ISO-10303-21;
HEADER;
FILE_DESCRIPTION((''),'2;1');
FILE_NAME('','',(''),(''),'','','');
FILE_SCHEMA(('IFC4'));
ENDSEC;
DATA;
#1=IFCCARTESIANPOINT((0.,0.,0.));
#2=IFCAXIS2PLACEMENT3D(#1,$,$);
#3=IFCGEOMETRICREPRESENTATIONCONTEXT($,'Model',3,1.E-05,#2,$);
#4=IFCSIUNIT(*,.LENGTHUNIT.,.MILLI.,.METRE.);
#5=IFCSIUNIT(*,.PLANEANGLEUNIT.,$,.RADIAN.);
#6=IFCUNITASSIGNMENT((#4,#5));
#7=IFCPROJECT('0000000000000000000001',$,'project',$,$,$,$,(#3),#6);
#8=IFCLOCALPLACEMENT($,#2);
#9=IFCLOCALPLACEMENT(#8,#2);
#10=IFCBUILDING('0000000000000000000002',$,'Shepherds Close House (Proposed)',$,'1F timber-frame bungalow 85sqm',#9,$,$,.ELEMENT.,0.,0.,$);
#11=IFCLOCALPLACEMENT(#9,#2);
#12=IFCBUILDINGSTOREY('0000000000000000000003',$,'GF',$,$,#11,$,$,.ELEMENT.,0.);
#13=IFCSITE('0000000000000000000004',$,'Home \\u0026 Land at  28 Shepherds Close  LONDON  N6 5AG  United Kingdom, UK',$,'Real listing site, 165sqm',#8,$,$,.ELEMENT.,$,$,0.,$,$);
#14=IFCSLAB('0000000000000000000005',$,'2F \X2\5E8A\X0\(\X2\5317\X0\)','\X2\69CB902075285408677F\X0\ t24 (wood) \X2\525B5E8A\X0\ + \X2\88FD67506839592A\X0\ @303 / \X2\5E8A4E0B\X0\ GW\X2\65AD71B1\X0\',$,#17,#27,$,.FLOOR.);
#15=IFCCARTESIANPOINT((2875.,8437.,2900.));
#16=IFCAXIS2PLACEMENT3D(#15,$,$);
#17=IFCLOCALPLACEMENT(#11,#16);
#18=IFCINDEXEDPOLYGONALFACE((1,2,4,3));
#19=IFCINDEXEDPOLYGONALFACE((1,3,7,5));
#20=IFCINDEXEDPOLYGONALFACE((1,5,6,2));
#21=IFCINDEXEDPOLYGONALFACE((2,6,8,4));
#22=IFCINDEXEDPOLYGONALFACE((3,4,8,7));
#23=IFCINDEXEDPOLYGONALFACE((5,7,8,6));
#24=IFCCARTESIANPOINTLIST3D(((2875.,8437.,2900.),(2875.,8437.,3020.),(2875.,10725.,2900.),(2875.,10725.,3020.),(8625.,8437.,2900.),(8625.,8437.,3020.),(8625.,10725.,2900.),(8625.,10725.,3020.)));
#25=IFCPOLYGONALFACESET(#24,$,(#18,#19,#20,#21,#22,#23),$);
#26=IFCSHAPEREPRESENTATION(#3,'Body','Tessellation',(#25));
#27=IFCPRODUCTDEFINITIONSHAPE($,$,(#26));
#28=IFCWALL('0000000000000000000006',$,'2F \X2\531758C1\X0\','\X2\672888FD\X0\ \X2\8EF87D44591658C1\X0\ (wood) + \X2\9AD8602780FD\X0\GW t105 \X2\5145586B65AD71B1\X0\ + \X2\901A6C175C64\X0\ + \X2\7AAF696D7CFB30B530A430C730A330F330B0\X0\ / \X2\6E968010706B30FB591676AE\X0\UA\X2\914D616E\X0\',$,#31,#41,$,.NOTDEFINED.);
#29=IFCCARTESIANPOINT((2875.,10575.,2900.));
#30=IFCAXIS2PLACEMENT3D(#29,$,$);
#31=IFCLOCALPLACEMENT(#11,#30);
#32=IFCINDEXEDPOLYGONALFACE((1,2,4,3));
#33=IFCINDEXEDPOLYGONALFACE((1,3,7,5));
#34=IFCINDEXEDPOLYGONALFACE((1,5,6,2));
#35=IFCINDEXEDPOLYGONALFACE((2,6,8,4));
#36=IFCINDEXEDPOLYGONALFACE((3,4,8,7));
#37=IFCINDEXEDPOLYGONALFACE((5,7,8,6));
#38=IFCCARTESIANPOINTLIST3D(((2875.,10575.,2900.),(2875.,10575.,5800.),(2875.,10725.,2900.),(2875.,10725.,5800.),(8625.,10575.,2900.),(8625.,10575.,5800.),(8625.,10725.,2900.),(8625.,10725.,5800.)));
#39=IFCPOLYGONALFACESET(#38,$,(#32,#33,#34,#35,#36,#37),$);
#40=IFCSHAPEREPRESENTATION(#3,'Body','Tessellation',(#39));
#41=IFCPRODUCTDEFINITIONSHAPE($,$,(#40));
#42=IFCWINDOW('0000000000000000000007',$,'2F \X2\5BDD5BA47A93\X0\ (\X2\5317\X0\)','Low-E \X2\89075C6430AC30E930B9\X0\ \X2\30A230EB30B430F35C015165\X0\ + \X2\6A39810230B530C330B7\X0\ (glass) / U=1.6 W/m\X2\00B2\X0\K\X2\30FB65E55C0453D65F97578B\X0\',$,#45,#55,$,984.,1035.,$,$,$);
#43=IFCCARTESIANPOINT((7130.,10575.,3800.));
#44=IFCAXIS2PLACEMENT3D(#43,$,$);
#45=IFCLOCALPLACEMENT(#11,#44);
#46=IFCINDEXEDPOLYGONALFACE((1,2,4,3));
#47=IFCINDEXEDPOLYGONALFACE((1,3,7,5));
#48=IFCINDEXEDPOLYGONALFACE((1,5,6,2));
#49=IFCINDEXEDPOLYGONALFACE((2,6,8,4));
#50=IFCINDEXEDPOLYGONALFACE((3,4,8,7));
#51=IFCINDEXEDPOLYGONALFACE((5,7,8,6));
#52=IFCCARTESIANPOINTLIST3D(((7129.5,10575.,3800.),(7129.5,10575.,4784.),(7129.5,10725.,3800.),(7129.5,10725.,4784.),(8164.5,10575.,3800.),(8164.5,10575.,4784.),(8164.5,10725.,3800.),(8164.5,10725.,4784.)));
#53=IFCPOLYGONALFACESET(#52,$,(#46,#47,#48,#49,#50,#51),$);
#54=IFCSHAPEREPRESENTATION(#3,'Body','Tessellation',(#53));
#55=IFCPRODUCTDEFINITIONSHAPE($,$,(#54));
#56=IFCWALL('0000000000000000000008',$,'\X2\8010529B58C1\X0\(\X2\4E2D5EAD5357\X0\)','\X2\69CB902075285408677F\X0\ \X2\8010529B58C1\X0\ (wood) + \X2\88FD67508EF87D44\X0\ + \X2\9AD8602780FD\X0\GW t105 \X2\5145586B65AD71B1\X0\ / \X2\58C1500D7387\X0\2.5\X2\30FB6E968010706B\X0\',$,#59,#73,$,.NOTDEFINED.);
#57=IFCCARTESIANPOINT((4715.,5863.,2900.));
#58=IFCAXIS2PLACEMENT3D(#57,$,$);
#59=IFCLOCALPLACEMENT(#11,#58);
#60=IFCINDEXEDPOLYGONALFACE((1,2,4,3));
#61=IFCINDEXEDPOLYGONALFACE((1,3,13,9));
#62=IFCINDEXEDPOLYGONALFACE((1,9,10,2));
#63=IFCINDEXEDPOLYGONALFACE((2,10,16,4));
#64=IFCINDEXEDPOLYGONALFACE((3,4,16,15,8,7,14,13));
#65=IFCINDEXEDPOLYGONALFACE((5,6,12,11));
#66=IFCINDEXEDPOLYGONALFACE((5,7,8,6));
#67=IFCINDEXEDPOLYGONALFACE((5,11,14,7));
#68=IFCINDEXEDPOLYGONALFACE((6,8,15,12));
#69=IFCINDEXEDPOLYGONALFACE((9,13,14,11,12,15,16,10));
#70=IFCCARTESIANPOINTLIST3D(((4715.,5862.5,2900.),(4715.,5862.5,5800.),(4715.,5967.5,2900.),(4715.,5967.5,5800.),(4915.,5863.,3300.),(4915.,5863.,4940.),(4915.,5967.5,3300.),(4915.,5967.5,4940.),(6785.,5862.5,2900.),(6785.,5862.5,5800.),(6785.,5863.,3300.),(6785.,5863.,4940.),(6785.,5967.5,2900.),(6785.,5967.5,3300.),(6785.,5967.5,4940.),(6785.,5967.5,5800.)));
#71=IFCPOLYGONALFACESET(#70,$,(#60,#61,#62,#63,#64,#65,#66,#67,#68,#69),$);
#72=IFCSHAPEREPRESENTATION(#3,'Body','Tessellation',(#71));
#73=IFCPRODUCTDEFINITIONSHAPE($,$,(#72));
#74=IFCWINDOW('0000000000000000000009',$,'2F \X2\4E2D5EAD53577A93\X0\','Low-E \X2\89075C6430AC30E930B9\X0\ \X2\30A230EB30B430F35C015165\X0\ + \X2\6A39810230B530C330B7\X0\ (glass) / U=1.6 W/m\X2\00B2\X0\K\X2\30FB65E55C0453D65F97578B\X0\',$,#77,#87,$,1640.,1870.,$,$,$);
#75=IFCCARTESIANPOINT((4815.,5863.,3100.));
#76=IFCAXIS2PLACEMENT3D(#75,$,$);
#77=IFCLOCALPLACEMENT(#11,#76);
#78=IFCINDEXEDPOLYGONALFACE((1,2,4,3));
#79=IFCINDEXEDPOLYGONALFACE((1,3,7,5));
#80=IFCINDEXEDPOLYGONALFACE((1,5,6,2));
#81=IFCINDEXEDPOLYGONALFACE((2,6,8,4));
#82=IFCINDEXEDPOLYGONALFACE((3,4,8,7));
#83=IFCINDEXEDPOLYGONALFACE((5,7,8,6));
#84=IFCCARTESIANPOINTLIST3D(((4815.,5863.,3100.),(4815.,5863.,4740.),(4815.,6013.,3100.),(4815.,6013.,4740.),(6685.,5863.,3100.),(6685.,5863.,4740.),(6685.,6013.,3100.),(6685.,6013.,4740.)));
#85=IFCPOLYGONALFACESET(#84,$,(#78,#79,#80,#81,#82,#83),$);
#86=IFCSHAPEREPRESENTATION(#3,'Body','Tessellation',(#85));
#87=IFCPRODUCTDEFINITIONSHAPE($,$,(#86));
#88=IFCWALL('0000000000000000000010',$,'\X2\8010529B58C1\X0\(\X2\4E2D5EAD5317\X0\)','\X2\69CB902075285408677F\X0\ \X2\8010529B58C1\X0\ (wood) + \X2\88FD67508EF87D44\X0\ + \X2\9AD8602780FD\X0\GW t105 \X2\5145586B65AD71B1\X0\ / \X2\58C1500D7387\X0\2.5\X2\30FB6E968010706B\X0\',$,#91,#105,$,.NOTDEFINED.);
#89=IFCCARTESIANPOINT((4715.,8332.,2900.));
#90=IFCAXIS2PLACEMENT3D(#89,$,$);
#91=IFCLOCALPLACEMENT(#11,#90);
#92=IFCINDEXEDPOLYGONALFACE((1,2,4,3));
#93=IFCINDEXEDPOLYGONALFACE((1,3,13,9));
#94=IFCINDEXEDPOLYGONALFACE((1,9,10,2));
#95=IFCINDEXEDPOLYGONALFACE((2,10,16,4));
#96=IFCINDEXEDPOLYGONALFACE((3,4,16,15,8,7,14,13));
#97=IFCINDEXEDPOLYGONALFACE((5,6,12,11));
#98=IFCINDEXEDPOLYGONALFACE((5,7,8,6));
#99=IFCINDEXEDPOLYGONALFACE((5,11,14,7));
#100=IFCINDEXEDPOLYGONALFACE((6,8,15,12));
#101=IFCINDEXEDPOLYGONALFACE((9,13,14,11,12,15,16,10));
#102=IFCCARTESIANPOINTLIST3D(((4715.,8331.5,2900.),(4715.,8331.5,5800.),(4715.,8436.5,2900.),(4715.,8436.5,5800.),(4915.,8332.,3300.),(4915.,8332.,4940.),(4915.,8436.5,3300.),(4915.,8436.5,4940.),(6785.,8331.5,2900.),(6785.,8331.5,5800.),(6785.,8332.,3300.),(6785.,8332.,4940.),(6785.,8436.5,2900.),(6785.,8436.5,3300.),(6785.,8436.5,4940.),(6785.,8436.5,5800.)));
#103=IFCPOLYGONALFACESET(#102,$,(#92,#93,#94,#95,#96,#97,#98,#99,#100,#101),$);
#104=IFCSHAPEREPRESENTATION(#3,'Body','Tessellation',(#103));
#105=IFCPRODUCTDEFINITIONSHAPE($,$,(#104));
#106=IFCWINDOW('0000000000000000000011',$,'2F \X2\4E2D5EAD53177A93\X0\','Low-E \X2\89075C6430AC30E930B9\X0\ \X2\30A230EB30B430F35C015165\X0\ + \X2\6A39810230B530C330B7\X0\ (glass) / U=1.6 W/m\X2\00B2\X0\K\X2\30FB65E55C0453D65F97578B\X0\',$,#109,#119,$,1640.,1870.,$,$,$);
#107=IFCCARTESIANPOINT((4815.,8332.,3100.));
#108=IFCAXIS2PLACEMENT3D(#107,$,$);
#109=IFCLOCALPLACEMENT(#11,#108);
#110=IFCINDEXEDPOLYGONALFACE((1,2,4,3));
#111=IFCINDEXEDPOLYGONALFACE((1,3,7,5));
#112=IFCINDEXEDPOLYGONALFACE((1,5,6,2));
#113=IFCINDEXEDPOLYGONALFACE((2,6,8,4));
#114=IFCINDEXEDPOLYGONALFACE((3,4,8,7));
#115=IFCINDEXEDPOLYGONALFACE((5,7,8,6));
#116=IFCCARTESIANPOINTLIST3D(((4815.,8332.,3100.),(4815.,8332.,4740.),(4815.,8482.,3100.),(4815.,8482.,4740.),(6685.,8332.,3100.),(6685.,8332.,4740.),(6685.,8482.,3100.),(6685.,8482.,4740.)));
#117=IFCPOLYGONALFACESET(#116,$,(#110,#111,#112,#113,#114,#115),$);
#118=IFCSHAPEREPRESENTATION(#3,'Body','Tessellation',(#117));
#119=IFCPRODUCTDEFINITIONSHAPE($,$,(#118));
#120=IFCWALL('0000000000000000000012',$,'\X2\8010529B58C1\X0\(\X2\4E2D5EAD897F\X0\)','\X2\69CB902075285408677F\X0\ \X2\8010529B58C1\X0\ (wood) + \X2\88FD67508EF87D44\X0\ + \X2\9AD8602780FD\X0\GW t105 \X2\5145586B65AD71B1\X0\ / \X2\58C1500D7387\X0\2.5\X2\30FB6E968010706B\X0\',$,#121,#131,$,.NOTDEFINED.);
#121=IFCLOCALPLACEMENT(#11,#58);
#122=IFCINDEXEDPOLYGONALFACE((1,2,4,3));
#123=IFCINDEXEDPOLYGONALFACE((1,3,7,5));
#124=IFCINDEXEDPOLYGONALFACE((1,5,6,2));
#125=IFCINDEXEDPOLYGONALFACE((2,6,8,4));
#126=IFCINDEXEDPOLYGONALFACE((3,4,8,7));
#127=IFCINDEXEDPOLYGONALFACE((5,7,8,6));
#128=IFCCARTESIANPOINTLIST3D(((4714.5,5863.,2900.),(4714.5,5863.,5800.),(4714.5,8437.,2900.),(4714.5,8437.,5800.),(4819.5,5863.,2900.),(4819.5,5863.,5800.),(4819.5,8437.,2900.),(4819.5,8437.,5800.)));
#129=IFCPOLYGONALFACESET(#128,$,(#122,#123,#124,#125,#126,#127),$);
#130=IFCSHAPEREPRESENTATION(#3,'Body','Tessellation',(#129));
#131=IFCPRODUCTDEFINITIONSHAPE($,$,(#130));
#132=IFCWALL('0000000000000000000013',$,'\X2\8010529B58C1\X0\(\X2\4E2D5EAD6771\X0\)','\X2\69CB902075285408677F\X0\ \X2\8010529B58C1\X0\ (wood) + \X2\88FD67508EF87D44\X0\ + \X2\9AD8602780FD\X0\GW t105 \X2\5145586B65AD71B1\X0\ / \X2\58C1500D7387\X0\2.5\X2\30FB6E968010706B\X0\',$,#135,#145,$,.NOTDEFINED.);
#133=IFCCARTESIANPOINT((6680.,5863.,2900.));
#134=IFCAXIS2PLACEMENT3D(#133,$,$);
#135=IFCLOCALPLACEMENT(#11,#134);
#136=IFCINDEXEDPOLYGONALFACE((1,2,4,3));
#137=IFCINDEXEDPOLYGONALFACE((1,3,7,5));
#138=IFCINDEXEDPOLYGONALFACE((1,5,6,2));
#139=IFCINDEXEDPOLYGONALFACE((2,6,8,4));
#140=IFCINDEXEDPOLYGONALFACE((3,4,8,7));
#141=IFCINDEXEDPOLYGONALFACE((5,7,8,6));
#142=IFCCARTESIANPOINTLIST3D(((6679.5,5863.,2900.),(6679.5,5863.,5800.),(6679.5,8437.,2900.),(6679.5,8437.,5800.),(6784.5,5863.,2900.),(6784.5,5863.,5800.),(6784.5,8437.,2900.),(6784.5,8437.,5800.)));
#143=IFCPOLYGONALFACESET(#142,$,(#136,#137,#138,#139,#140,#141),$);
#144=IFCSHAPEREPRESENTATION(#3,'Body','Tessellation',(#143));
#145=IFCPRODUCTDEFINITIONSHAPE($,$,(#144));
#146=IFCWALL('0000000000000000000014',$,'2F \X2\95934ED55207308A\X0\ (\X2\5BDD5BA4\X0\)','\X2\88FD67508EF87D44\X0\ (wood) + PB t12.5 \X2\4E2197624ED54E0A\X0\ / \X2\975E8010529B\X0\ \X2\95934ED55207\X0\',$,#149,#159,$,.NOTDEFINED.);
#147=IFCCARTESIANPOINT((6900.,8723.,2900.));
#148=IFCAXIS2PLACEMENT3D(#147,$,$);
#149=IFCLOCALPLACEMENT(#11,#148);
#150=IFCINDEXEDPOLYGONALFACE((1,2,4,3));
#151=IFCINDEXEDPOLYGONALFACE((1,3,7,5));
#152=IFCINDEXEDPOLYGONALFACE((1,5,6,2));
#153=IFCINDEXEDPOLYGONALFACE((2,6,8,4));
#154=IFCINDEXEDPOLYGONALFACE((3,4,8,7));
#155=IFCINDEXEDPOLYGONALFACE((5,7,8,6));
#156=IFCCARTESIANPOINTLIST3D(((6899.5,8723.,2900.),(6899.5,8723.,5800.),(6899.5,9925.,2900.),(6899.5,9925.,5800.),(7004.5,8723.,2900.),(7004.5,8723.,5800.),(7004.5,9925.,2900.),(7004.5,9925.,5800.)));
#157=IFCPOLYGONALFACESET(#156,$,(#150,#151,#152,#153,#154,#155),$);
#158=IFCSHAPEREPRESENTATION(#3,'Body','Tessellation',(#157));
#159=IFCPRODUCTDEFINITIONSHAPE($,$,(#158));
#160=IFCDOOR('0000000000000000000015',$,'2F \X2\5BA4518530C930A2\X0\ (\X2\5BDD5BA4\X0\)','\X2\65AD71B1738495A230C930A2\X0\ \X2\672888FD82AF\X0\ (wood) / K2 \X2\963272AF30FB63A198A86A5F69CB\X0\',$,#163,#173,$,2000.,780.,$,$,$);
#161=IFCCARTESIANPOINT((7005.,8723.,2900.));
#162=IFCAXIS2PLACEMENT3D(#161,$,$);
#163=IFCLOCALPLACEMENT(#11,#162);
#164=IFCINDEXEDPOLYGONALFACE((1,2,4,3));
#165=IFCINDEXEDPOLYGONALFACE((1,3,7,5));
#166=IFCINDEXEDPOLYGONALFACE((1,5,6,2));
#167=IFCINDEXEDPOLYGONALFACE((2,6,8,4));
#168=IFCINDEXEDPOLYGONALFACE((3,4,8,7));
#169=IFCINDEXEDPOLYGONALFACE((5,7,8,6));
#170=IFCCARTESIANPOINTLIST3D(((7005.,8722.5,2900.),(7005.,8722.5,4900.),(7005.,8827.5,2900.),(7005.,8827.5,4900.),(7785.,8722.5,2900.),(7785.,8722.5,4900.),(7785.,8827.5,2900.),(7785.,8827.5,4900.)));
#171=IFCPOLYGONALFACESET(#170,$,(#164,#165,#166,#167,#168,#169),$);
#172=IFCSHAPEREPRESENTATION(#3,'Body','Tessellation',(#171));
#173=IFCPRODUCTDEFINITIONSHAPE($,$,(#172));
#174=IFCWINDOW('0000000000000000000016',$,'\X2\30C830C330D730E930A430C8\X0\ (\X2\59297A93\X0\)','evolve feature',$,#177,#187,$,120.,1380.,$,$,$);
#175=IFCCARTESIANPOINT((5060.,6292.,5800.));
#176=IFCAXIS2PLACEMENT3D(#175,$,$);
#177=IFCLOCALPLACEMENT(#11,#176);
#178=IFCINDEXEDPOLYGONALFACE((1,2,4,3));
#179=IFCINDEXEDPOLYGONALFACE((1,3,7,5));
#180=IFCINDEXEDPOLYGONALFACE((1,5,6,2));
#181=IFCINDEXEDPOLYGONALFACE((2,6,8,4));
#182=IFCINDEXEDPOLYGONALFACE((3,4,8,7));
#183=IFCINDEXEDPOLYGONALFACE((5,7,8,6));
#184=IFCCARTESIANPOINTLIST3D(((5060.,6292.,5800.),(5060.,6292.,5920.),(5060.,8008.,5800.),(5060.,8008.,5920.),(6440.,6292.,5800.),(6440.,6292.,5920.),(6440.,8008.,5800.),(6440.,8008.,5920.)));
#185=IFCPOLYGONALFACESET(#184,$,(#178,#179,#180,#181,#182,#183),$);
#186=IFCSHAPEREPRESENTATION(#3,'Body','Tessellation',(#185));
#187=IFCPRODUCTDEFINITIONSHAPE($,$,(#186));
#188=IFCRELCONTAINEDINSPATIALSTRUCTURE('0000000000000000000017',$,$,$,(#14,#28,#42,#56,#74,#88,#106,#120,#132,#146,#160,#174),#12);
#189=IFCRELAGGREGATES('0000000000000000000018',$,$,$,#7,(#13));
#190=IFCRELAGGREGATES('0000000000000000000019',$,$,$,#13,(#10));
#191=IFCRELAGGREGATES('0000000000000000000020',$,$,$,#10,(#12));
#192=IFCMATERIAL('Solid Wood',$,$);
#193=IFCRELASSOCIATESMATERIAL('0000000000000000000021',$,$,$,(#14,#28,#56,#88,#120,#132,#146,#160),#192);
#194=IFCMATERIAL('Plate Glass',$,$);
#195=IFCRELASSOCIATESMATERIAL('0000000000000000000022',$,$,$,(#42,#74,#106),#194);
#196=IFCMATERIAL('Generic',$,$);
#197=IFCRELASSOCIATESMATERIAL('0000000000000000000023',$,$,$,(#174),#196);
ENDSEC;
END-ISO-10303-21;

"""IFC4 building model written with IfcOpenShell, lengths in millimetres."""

from ifc_helpers import new_model, si_unit, frame, frame_2d, origin, place, context, project, spatial, rectangle, extrude, material, element, fill, save


model = new_model("IFC4")

# Units and contexts
model_context = context("Model", 3, precision=1e-05, world=origin())
ifc_project = project(units=[si_unit("LENGTHUNIT", "METRE", prefix="MILLI"), si_unit("PLANEANGLEUNIT", "RADIAN")], contexts=[model_context])

# Site, building, storey
site_placement = place(None, origin())
site = spatial("IfcSite", under=ifc_project, at=site_placement, Name="Home \\u0026 Land at  28 Shepherds Close  LONDON  N6 5AG  United Kingdom, UK", ObjectType="Real listing site, 165sqm", CompositionType="ELEMENT", RefElevation=0.0)
building_placement = place(site_placement, origin())
building = spatial("IfcBuilding", under=site, at=building_placement, Name="Shepherds Close House (Proposed)", ObjectType="1F timber-frame bungalow 85sqm", CompositionType="ELEMENT", ElevationOfRefHeight=0.0, ElevationOfTerrain=0.0)
storey_placement = place(building_placement, origin())
storey = spatial("IfcBuildingStorey", under=building, at=storey_placement, Name="GF", CompositionType="ELEMENT", Elevation=0.0)

# Slab
ifc_material_1 = material(Name="Solid Wood")
slab_placement = place(storey_placement, frame((2875.0, 8437.0, 2900.0)))
element("IfcSlab", 1, at=slab_placement, inside=storey, material=ifc_material_1, Name="2F 床(北)", Description="構造用合板 t24 (wood) 剛床 + 製材根太 @303 / 床下 GW断熱", PredefinedType="FLOOR", context=model_context, shape_type="SweptSolid", body=[
    extrude(rectangle(XDim=5750.0, YDim=2288.0, at=frame_2d((2875.0, 1144.0))), frame((2875.0, 8437.0, 2900.0)), (0.0, 0.0, 1.0), 120.0),
])

# Walls, openings, windows
wall_1_placement = place(storey_placement, frame((2875.0, 10575.0, 2900.0)))
wall_1 = element("IfcWall", 2, at=wall_1_placement, inside=storey, material=ifc_material_1, Name="2F 北壁", Description="木製 軸組外壁 (wood) + 高性能GW t105 充填断熱 + 通気層 + 窯業系サイディング / 準耐火・外皮UA配慮", PredefinedType="NOTDEFINED", context=model_context, shape_type="SweptSolid", body=[
    extrude(rectangle(XDim=5750.0, YDim=150.0, at=frame_2d((2875.0, 75.0))), frame((2875.0, 10575.0, 2900.0)), (0.0, 0.0, 1.0), 2900.0),
])
opening_1_placement = place(storey_placement, frame((7130.0, 10575.0, 3800.0)))
opening_1 = element("IfcOpeningElement", 3, at=opening_1_placement, cuts=wall_1, PredefinedType="NOTDEFINED", context=model_context, shape_type="SweptSolid", body=[
    extrude(rectangle(XDim=1035.0, YDim=150.0, at=frame_2d((517.0, 75.0))), frame((7130.0, 10575.0, 3800.0)), (0.0, 0.0, 1.0), 984.0),
])
ifc_material_2 = material(Name="Plate Glass")
window_1_placement = place(storey_placement, frame((7130.0, 10575.0, 3800.0)))
window_1 = element("IfcWindow", 4, at=window_1_placement, inside=storey, material=ifc_material_2, Name="2F 寝室窓 (北)", Description="Low-E 複層ガラス アルゴン封入 + 樹脂サッシ (glass) / U=1.6 W/m²K・日射取得型", OverallHeight=984.0, OverallWidth=1035.0, context=model_context, shape_type="SweptSolid", body=[
    extrude(rectangle(XDim=1035.0, YDim=150.0, at=frame_2d((517.0, 75.0))), frame((7130.0, 10575.0, 3800.0)), (0.0, 0.0, 1.0), 984.0),
])
fill(opening_1, window_1)
wall_2_placement = place(storey_placement, frame((4715.0, 5863.0, 2900.0)))
wall_2 = element("IfcWall", 5, at=wall_2_placement, inside=storey, material=ifc_material_1, Name="耐力壁(中庭南)", Description="構造用合板 耐力壁 (wood) + 製材軸組 + 高性能GW t105 充填断熱 / 壁倍率2.5・準耐火", PredefinedType="NOTDEFINED", context=model_context, shape_type="SweptSolid", body=[
    extrude(rectangle(XDim=2070.0, YDim=105.0, at=frame_2d((1035.0, 52.0))), frame((4715.0, 5863.0, 2900.0)), (0.0, 0.0, 1.0), 2900.0),
])
opening_2_placement = place(storey_placement, frame((4815.0, 5863.0, 3100.0)))
opening_2 = element("IfcOpeningElement", 6, at=opening_2_placement, cuts=wall_2, PredefinedType="NOTDEFINED", context=model_context, shape_type="SweptSolid", body=[
    extrude(rectangle(XDim=1870.0, YDim=150.0, at=frame_2d((935.0, 75.0))), frame((4815.0, 5863.0, 3100.0)), (0.0, 0.0, 1.0), 1640.0),
])
window_2_placement = place(storey_placement, frame((4815.0, 5863.0, 3100.0)))
window_2 = element("IfcWindow", 7, at=window_2_placement, inside=storey, material=ifc_material_2, Name="2F 中庭南窓", Description="Low-E 複層ガラス アルゴン封入 + 樹脂サッシ (glass) / U=1.6 W/m²K・日射取得型", OverallHeight=1640.0, OverallWidth=1870.0, context=model_context, shape_type="SweptSolid", body=[
    extrude(rectangle(XDim=1870.0, YDim=150.0, at=frame_2d((935.0, 75.0))), frame((4815.0, 5863.0, 3100.0)), (0.0, 0.0, 1.0), 1640.0),
])
fill(opening_2, window_2)
wall_3_placement = place(storey_placement, frame((4715.0, 8332.0, 2900.0)))
wall_3 = element("IfcWall", 8, at=wall_3_placement, inside=storey, material=ifc_material_1, Name="耐力壁(中庭北)", Description="構造用合板 耐力壁 (wood) + 製材軸組 + 高性能GW t105 充填断熱 / 壁倍率2.5・準耐火", PredefinedType="NOTDEFINED", context=model_context, shape_type="SweptSolid", body=[
    extrude(rectangle(XDim=2070.0, YDim=105.0, at=frame_2d((1035.0, 52.0))), frame((4715.0, 8332.0, 2900.0)), (0.0, 0.0, 1.0), 2900.0),
])
opening_3_placement = place(storey_placement, frame((4815.0, 8332.0, 3100.0)))
opening_3 = element("IfcOpeningElement", 9, at=opening_3_placement, cuts=wall_3, PredefinedType="NOTDEFINED", context=model_context, shape_type="SweptSolid", body=[
    extrude(rectangle(XDim=1870.0, YDim=150.0, at=frame_2d((935.0, 75.0))), frame((4815.0, 8332.0, 3100.0)), (0.0, 0.0, 1.0), 1640.0),
])
window_3_placement = place(storey_placement, frame((4815.0, 8332.0, 3100.0)))
window_3 = element("IfcWindow", 10, at=window_3_placement, inside=storey, material=ifc_material_2, Name="2F 中庭北窓", Description="Low-E 複層ガラス アルゴン封入 + 樹脂サッシ (glass) / U=1.6 W/m²K・日射取得型", OverallHeight=1640.0, OverallWidth=1870.0, context=model_context, shape_type="SweptSolid", body=[
    extrude(rectangle(XDim=1870.0, YDim=150.0, at=frame_2d((935.0, 75.0))), frame((4815.0, 8332.0, 3100.0)), (0.0, 0.0, 1.0), 1640.0),
])
fill(opening_3, window_3)

# Walls
wall_4_placement = place(storey_placement, frame((4715.0, 5863.0, 2900.0)))
element("IfcWall", 11, at=wall_4_placement, inside=storey, material=ifc_material_1, Name="耐力壁(中庭西)", Description="構造用合板 耐力壁 (wood) + 製材軸組 + 高性能GW t105 充填断熱 / 壁倍率2.5・準耐火", PredefinedType="NOTDEFINED", context=model_context, shape_type="SweptSolid", body=[
    extrude(rectangle(XDim=105.0, YDim=2574.0, at=frame_2d((52.0, 1287.0))), frame((4715.0, 5863.0, 2900.0)), (0.0, 0.0, 1.0), 2900.0),
])
wall_5_placement = place(storey_placement, frame((6680.0, 5863.0, 2900.0)))
element("IfcWall", 12, at=wall_5_placement, inside=storey, material=ifc_material_1, Name="耐力壁(中庭東)", Description="構造用合板 耐力壁 (wood) + 製材軸組 + 高性能GW t105 充填断熱 / 壁倍率2.5・準耐火", PredefinedType="NOTDEFINED", context=model_context, shape_type="SweptSolid", body=[
    extrude(rectangle(XDim=105.0, YDim=2574.0, at=frame_2d((52.0, 1287.0))), frame((6680.0, 5863.0, 2900.0)), (0.0, 0.0, 1.0), 2900.0),
])
wall_6_placement = place(storey_placement, frame((6900.0, 8723.0, 2900.0)))
element("IfcWall", 13, at=wall_6_placement, inside=storey, material=ifc_material_1, Name="2F 間仕切り (寝室)", Description="製材軸組 (wood) + PB t12.5 両面仕上 / 非耐力 間仕切", PredefinedType="NOTDEFINED", context=model_context, shape_type="SweptSolid", body=[
    extrude(rectangle(XDim=105.0, YDim=1202.0, at=frame_2d((52.0, 601.0))), frame((6900.0, 8723.0, 2900.0)), (0.0, 0.0, 1.0), 2900.0),
])

# Door
door_placement = place(storey_placement, frame((7005.0, 8723.0, 2900.0)))
element("IfcDoor", 14, at=door_placement, inside=storey, material=ifc_material_1, Name="2F 室内ドア (寝室)", Description="断熱玄関ドア 木製芯 (wood) / K2 防犯・採風機構", OverallHeight=2000.0, OverallWidth=780.0, context=model_context, shape_type="SweptSolid", body=[
    extrude(rectangle(XDim=780.0, YDim=105.0, at=frame_2d((390.0, 52.0))), frame((7005.0, 8723.0, 2900.0)), (0.0, 0.0, 1.0), 2000.0),
])

# Window
ifc_material_3 = material(Name="Generic")
window_4_placement = place(storey_placement, frame((5060.0, 6292.0, 5800.0)))
element("IfcWindow", 15, at=window_4_placement, inside=storey, material=ifc_material_3, Name="トップライト (天窓)", Description="evolve feature", OverallHeight=120.0, OverallWidth=1380.0, context=model_context, shape_type="SweptSolid", body=[
    extrude(rectangle(XDim=1380.0, YDim=1716.0, at=frame_2d((690.0, 858.0))), frame((5060.0, 6292.0, 5800.0)), (0.0, 0.0, 1.0), 120.0),
])

save(model, "model.ifc")
